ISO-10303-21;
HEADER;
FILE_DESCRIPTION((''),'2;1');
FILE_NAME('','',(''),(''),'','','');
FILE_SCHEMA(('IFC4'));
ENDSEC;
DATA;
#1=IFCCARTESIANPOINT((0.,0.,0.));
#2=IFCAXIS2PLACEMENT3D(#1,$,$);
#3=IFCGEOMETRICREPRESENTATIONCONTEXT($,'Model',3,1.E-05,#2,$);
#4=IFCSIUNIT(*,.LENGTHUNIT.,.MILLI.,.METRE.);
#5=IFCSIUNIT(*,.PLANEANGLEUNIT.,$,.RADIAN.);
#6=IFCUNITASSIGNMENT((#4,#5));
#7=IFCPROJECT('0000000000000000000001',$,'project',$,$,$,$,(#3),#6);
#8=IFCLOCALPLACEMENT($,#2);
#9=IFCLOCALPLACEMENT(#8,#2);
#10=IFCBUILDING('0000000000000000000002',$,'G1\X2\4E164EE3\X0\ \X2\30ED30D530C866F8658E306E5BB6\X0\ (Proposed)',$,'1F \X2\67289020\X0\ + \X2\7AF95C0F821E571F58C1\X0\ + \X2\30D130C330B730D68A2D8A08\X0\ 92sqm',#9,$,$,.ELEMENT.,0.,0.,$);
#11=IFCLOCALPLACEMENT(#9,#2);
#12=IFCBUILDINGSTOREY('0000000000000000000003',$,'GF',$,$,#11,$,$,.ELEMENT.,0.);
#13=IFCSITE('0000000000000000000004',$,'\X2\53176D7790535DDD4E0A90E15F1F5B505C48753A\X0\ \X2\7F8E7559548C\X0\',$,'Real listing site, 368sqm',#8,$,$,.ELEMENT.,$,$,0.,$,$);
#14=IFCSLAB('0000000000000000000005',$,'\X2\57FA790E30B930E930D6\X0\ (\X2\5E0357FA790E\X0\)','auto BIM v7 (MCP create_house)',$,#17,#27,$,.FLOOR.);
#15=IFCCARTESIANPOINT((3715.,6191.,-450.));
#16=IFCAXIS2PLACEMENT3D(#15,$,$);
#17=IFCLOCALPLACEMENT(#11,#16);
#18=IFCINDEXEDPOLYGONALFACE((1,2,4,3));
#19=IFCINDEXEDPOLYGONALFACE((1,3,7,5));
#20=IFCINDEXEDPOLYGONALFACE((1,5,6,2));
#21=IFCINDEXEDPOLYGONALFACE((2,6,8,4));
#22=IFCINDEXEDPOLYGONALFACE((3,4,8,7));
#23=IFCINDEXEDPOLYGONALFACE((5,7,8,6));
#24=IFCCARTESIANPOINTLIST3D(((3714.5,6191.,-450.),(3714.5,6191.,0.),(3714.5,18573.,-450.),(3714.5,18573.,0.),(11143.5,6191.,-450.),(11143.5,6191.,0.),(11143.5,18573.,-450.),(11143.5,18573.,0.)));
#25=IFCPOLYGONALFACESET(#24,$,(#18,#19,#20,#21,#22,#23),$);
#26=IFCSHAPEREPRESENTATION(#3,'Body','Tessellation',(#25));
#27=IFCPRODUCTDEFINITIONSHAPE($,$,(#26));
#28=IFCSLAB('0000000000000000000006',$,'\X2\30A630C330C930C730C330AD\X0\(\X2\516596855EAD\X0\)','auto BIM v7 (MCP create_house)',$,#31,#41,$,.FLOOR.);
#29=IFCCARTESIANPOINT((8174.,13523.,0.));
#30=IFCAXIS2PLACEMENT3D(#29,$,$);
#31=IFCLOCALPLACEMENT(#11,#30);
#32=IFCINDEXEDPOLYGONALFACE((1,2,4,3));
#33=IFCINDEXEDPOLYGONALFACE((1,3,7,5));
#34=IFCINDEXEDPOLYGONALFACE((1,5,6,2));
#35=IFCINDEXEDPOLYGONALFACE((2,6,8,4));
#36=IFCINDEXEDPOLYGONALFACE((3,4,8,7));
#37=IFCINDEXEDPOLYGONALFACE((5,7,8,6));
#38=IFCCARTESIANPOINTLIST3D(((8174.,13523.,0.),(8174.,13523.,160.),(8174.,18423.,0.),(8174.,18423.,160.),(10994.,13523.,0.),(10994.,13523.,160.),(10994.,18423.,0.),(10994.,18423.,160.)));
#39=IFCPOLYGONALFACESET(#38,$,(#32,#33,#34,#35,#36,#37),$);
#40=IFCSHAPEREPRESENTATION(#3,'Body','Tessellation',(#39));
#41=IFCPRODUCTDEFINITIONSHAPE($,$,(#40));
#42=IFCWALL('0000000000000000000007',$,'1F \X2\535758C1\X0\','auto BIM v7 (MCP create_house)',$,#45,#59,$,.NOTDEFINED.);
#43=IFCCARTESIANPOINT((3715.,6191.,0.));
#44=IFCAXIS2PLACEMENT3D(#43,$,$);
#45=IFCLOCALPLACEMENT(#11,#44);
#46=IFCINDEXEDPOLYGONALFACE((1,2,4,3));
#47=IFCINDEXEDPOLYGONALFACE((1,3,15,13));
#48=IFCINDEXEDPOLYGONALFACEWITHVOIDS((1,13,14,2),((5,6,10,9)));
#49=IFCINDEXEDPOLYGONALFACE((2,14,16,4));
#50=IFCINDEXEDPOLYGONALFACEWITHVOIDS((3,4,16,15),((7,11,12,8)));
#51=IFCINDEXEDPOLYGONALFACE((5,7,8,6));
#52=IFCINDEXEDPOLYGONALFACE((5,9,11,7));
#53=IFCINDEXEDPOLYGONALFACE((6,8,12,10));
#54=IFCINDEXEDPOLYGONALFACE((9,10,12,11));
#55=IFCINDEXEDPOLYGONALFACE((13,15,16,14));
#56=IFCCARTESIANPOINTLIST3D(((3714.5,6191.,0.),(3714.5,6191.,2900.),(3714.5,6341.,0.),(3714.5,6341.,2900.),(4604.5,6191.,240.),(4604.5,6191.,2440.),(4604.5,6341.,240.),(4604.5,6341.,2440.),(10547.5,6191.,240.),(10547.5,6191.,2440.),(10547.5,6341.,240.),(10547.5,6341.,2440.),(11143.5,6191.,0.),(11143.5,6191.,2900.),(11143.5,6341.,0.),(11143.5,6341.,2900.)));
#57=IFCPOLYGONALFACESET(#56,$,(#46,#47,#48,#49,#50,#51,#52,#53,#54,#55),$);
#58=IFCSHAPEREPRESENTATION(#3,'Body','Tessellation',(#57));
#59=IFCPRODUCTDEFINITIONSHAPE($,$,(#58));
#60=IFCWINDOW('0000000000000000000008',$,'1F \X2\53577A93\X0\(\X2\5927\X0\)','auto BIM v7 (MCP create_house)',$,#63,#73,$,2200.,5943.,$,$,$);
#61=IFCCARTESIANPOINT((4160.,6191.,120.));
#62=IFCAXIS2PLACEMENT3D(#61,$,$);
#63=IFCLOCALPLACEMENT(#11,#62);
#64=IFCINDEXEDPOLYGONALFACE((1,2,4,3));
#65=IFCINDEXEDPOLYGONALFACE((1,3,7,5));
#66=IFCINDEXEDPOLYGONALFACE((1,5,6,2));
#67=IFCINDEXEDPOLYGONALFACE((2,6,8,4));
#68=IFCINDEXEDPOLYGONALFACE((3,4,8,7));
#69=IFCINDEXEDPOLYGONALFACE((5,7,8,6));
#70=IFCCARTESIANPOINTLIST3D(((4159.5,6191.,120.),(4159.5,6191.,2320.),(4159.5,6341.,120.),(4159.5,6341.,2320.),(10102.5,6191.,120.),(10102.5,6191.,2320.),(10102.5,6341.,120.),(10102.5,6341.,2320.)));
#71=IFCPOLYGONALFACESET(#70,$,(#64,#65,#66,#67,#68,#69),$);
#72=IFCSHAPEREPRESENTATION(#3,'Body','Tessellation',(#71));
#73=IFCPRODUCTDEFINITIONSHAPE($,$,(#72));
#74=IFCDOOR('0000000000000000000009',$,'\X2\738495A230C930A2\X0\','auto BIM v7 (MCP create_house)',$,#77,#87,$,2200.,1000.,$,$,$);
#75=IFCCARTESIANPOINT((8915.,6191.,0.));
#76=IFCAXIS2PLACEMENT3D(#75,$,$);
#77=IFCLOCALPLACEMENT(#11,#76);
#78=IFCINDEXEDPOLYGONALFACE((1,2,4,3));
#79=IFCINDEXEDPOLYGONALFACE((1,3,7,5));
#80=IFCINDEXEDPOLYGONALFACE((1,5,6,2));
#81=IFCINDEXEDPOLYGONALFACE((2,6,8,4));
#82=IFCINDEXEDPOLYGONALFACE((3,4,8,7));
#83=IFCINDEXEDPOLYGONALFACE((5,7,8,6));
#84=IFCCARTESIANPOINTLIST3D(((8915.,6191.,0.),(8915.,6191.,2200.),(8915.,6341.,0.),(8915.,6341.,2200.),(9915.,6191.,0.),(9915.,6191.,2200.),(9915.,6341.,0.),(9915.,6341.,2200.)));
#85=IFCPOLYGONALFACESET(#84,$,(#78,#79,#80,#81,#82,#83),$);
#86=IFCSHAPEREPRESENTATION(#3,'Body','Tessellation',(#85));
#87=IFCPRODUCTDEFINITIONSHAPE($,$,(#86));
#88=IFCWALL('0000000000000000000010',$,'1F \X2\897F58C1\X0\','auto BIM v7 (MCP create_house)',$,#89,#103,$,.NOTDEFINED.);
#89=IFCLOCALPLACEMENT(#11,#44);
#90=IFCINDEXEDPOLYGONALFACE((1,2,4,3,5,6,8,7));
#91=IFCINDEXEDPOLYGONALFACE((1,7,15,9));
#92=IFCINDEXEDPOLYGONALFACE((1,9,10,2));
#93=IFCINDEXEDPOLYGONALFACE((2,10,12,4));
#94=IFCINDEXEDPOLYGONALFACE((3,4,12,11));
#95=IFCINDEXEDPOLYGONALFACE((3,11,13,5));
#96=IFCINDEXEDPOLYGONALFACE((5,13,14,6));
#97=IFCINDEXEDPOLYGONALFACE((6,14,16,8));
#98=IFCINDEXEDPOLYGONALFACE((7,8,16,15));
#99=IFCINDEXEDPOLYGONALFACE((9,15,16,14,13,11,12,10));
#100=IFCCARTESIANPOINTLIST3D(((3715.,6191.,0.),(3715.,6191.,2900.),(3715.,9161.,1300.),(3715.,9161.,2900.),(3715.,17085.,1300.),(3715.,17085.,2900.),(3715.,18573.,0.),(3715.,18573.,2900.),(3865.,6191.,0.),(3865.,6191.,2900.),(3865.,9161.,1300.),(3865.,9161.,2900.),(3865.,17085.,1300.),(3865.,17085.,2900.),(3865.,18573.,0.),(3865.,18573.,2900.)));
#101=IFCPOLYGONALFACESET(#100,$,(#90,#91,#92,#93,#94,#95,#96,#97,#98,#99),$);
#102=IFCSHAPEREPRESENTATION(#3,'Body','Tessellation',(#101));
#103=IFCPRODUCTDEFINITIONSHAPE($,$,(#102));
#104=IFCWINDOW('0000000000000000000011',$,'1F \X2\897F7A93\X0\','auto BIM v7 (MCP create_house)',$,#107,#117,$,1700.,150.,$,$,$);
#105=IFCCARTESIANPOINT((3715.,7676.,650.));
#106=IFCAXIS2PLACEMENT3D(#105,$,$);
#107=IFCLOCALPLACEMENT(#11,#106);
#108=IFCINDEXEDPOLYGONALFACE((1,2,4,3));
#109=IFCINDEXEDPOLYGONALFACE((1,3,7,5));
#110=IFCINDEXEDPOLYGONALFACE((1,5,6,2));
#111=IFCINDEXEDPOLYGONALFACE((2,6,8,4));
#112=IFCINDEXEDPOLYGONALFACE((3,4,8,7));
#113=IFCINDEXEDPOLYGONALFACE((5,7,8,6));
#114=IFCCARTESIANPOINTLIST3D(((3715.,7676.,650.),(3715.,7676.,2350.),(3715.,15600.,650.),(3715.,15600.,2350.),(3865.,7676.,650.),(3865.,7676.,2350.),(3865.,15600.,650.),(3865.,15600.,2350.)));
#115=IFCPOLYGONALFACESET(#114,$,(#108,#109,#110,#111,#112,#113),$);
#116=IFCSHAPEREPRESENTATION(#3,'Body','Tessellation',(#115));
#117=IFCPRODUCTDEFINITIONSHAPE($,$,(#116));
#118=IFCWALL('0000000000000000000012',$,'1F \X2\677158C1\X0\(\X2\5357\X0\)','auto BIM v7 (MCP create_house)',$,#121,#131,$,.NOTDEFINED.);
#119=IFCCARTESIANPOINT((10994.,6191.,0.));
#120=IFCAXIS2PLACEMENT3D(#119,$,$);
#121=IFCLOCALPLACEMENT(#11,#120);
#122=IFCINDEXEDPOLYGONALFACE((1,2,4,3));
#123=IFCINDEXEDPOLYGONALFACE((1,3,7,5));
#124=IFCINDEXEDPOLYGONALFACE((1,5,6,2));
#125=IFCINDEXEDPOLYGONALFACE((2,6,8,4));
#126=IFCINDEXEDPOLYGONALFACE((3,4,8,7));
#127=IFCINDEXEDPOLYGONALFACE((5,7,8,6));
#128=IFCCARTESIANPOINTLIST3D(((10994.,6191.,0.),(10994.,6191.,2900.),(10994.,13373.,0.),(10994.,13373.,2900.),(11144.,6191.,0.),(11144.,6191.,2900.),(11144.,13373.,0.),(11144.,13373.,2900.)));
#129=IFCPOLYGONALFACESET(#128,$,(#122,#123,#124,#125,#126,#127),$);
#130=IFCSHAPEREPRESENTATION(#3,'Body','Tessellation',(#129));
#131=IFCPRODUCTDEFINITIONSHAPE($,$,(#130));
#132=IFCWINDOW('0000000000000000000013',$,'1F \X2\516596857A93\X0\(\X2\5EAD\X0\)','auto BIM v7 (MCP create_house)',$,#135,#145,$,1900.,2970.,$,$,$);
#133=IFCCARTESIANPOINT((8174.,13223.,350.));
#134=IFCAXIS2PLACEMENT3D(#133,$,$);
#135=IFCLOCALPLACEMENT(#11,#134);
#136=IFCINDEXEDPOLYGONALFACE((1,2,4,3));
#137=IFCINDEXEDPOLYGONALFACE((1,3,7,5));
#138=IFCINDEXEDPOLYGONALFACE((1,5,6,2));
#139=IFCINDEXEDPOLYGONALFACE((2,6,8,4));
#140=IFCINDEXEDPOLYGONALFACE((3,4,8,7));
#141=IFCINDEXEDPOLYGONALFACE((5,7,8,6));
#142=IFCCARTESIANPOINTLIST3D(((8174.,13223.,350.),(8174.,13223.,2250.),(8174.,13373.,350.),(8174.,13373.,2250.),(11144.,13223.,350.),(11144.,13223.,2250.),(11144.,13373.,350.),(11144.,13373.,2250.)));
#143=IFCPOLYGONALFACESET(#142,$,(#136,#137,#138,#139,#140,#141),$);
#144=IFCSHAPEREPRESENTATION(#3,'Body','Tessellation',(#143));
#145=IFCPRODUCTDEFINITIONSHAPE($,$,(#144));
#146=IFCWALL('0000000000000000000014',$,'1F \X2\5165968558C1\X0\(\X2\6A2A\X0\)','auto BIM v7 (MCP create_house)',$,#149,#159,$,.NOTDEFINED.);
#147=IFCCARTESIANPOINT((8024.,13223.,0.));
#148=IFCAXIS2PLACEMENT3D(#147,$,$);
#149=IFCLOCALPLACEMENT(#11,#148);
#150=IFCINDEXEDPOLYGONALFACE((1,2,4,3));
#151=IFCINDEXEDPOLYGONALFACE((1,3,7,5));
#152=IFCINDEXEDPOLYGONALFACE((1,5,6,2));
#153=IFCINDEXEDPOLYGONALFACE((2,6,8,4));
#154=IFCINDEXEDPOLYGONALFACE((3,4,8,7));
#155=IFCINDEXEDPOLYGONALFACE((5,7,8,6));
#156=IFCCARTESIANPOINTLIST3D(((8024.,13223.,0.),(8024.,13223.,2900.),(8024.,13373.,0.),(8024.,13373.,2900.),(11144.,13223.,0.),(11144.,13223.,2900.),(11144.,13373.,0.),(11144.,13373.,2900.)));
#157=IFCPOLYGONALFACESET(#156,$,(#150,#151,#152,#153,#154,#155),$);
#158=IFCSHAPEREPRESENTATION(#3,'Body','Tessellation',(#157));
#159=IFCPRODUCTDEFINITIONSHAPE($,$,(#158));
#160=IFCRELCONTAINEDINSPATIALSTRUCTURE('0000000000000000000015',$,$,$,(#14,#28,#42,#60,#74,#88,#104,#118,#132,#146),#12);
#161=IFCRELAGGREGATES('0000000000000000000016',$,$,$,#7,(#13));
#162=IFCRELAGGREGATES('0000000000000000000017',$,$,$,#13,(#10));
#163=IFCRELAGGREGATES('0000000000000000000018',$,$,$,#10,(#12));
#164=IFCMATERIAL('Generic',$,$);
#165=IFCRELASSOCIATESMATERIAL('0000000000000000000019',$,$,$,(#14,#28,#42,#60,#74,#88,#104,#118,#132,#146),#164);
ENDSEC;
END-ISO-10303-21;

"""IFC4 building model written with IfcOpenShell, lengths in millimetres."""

from ifc_helpers import new_model, si_unit, frame, frame_2d, origin, place, context, project, spatial, rectangle, extrude, material, element, fill, save


model = new_model("IFC4")

# Units and contexts
model_context = context("Model", 3, precision=1e-05, world=origin())
ifc_project = project(units=[si_unit("LENGTHUNIT", "METRE", prefix="MILLI"), si_unit("PLANEANGLEUNIT", "RADIAN")], contexts=[model_context])

# Site, building, storey
site_placement = place(None, origin())
site = spatial("IfcSite", under=ifc_project, at=site_placement, Name="北海道川上郡弟子屈町 美留和", ObjectType="Real listing site, 368sqm", CompositionType="ELEMENT", RefElevation=0.0)
building_placement = place(site_placement, origin())
building = spatial("IfcBuilding", under=site, at=building_placement, Name="G1世代 ロフト書斎の家 (Proposed)", ObjectType="1F 木造 + 竹小舞土壁 + パッシブ設計 92sqm", CompositionType="ELEMENT", ElevationOfRefHeight=0.0, ElevationOfTerrain=0.0)
storey_placement = place(building_placement, origin())
storey = spatial("IfcBuildingStorey", under=building, at=storey_placement, Name="GF", CompositionType="ELEMENT", Elevation=0.0)

# Slabs
ifc_material = material(Name="Generic")
slab_1_placement = place(storey_placement, frame((3715.0, 6191.0, -450.0)))
element("IfcSlab", 1, at=slab_1_placement, inside=storey, material=ifc_material, Name="基礎スラブ (布基礎)", Description="auto BIM v7 (MCP create_house)", PredefinedType="FLOOR", context=model_context, shape_type="SweptSolid", body=[
    extrude(rectangle(XDim=7429.0, YDim=12382.0, at=frame_2d((3714.0, 6191.0))), frame((3715.0, 6191.0, -450.0)), (0.0, 0.0, 1.0), 450.0),
])
slab_2_placement = place(storey_placement, frame((8174.0, 13523.0, 0.0)))
element("IfcSlab", 2, at=slab_2_placement, inside=storey, material=ifc_material, Name="ウッドデッキ(入隅庭)", Description="auto BIM v7 (MCP create_house)", PredefinedType="FLOOR", context=model_context, shape_type="SweptSolid", body=[
    extrude(rectangle(XDim=2820.0, YDim=4900.0, at=frame_2d((1410.0, 2450.0))), frame((8174.0, 13523.0, 0.0)), (0.0, 0.0, 1.0), 160.0),
])

# Wall, openings, window, door
wall_1_placement = place(storey_placement, frame((3715.0, 6191.0, 0.0)))
wall_1 = element("IfcWall", 3, at=wall_1_placement, inside=storey, material=ifc_material, Name="1F 南壁", Description="auto BIM v7 (MCP create_house)", PredefinedType="NOTDEFINED", context=model_context, shape_type="SweptSolid", body=[
    extrude(rectangle(XDim=7429.0, YDim=150.0, at=frame_2d((3714.0, 75.0))), frame((3715.0, 6191.0, 0.0)), (0.0, 0.0, 1.0), 2900.0),
])
opening_1_placement = place(storey_placement, frame((4160.0, 6191.0, 120.0)))
opening_1 = element("IfcOpeningElement", 4, at=opening_1_placement, cuts=wall_1, PredefinedType="NOTDEFINED", context=model_context, shape_type="SweptSolid", body=[
    extrude(rectangle(XDim=5943.0, YDim=150.0, at=frame_2d((2971.0, 75.0))), frame((4160.0, 6191.0, 120.0)), (0.0, 0.0, 1.0), 2200.0),
])
opening_2_placement = place(storey_placement, frame((8915.0, 6191.0, 0.0)))
opening_2 = element("IfcOpeningElement", 5, at=opening_2_placement, cuts=wall_1, PredefinedType="NOTDEFINED", context=model_context, shape_type="SweptSolid", body=[
    extrude(rectangle(XDim=1000.0, YDim=150.0, at=frame_2d((500.0, 75.0))), frame((8915.0, 6191.0, 0.0)), (0.0, 0.0, 1.0), 2200.0),
])
window_1_placement = place(storey_placement, frame((4160.0, 6191.0, 120.0)))
window_1 = element("IfcWindow", 6, at=window_1_placement, inside=storey, material=ifc_material, Name="1F 南窓(大)", Description="auto BIM v7 (MCP create_house)", OverallHeight=2200.0, OverallWidth=5943.0, context=model_context, shape_type="SweptSolid", body=[
    extrude(rectangle(XDim=5943.0, YDim=150.0, at=frame_2d((2971.0, 75.0))), frame((4160.0, 6191.0, 120.0)), (0.0, 0.0, 1.0), 2200.0),
])
fill(opening_1, window_1)
door_placement = place(storey_placement, frame((8915.0, 6191.0, 0.0)))
door = element("IfcDoor", 7, at=door_placement, inside=storey, material=ifc_material, Name="玄関ドア", Description="auto BIM v7 (MCP create_house)", OverallHeight=2200.0, OverallWidth=1000.0, context=model_context, shape_type="SweptSolid", body=[
    extrude(rectangle(XDim=1000.0, YDim=150.0, at=frame_2d((500.0, 75.0))), frame((8915.0, 6191.0, 0.0)), (0.0, 0.0, 1.0), 2200.0),
])
fill(opening_2, door)

# Wall, opening, window
wall_2_placement = place(storey_placement, frame((3715.0, 6191.0, 0.0)))
wall_2 = element("IfcWall", 8, at=wall_2_placement, inside=storey, material=ifc_material, Name="1F 西壁", Description="auto BIM v7 (MCP create_house)", PredefinedType="NOTDEFINED", context=model_context, shape_type="SweptSolid", body=[
    extrude(rectangle(XDim=150.0, YDim=12382.0, at=frame_2d((75.0, 6191.0))), frame((3715.0, 6191.0, 0.0)), (0.0, 0.0, 1.0), 2900.0),
])
opening_3_placement = place(storey_placement, frame((3715.0, 7676.0, 650.0)))
opening_3 = element("IfcOpeningElement", 9, at=opening_3_placement, cuts=wall_2, PredefinedType="NOTDEFINED", context=model_context, shape_type="SweptSolid", body=[
    extrude(rectangle(XDim=150.0, YDim=7924.0, at=frame_2d((75.0, 3962.0))), frame((3715.0, 7676.0, 650.0)), (0.0, 0.0, 1.0), 1700.0),
])
window_2_placement = place(storey_placement, frame((3715.0, 7676.0, 650.0)))
window_2 = element("IfcWindow", 10, at=window_2_placement, inside=storey, material=ifc_material, Name="1F 西窓", Description="auto BIM v7 (MCP create_house)", OverallHeight=1700.0, OverallWidth=150.0, context=model_context, shape_type="SweptSolid", body=[
    extrude(rectangle(XDim=150.0, YDim=7924.0, at=frame_2d((75.0, 3962.0))), frame((3715.0, 7676.0, 650.0)), (0.0, 0.0, 1.0), 1700.0),
])
fill(opening_3, window_2)

# Wall, opening, window
wall_3_placement = place(storey_placement, frame((10994.0, 6191.0, 0.0)))
wall_3 = element("IfcWall", 11, at=wall_3_placement, inside=storey, material=ifc_material, Name="1F 東壁(南)", Description="auto BIM v7 (MCP create_house)", PredefinedType="NOTDEFINED", context=model_context, shape_type="SweptSolid", body=[
    extrude(rectangle(XDim=150.0, YDim=7182.0, at=frame_2d((75.0, 3591.0))), frame((10994.0, 6191.0, 0.0)), (0.0, 0.0, 1.0), 2900.0),
])
opening_4_placement = place(storey_placement, frame((8174.0, 13223.0, 350.0)))
opening_4 = element("IfcOpeningElement", 12, at=opening_4_placement, cuts=wall_3, PredefinedType="NOTDEFINED", context=model_context, shape_type="SweptSolid", body=[
    extrude(rectangle(XDim=2970.0, YDim=150.0, at=frame_2d((1485.0, 75.0))), frame((8174.0, 13223.0, 350.0)), (0.0, 0.0, 1.0), 1900.0),
])
window_3_placement = place(storey_placement, frame((8174.0, 13223.0, 350.0)))
window_3 = element("IfcWindow", 13, at=window_3_placement, inside=storey, material=ifc_material, Name="1F 入隅窓(庭)", Description="auto BIM v7 (MCP create_house)", OverallHeight=1900.0, OverallWidth=2970.0, context=model_context, shape_type="SweptSolid", body=[
    extrude(rectangle(XDim=2970.0, YDim=150.0, at=frame_2d((1485.0, 75.0))), frame((8174.0, 13223.0, 350.0)), (0.0, 0.0, 1.0), 1900.0),
])
fill(opening_4, window_3)

# Wall
wall_4_placement = place(storey_placement, frame((8024.0, 13223.0, 0.0)))
element("IfcWall", 14, at=wall_4_placement, inside=storey, material=ifc_material, Name="1F 入隅壁(横)", Description="auto BIM v7 (MCP create_house)", PredefinedType="NOTDEFINED", context=model_context, shape_type="SweptSolid", body=[
    extrude(rectangle(XDim=3120.0, YDim=150.0, at=frame_2d((1560.0, 75.0))), frame((8024.0, 13223.0, 0.0)), (0.0, 0.0, 1.0), 2900.0),
])

save(model, "model.ifc")
